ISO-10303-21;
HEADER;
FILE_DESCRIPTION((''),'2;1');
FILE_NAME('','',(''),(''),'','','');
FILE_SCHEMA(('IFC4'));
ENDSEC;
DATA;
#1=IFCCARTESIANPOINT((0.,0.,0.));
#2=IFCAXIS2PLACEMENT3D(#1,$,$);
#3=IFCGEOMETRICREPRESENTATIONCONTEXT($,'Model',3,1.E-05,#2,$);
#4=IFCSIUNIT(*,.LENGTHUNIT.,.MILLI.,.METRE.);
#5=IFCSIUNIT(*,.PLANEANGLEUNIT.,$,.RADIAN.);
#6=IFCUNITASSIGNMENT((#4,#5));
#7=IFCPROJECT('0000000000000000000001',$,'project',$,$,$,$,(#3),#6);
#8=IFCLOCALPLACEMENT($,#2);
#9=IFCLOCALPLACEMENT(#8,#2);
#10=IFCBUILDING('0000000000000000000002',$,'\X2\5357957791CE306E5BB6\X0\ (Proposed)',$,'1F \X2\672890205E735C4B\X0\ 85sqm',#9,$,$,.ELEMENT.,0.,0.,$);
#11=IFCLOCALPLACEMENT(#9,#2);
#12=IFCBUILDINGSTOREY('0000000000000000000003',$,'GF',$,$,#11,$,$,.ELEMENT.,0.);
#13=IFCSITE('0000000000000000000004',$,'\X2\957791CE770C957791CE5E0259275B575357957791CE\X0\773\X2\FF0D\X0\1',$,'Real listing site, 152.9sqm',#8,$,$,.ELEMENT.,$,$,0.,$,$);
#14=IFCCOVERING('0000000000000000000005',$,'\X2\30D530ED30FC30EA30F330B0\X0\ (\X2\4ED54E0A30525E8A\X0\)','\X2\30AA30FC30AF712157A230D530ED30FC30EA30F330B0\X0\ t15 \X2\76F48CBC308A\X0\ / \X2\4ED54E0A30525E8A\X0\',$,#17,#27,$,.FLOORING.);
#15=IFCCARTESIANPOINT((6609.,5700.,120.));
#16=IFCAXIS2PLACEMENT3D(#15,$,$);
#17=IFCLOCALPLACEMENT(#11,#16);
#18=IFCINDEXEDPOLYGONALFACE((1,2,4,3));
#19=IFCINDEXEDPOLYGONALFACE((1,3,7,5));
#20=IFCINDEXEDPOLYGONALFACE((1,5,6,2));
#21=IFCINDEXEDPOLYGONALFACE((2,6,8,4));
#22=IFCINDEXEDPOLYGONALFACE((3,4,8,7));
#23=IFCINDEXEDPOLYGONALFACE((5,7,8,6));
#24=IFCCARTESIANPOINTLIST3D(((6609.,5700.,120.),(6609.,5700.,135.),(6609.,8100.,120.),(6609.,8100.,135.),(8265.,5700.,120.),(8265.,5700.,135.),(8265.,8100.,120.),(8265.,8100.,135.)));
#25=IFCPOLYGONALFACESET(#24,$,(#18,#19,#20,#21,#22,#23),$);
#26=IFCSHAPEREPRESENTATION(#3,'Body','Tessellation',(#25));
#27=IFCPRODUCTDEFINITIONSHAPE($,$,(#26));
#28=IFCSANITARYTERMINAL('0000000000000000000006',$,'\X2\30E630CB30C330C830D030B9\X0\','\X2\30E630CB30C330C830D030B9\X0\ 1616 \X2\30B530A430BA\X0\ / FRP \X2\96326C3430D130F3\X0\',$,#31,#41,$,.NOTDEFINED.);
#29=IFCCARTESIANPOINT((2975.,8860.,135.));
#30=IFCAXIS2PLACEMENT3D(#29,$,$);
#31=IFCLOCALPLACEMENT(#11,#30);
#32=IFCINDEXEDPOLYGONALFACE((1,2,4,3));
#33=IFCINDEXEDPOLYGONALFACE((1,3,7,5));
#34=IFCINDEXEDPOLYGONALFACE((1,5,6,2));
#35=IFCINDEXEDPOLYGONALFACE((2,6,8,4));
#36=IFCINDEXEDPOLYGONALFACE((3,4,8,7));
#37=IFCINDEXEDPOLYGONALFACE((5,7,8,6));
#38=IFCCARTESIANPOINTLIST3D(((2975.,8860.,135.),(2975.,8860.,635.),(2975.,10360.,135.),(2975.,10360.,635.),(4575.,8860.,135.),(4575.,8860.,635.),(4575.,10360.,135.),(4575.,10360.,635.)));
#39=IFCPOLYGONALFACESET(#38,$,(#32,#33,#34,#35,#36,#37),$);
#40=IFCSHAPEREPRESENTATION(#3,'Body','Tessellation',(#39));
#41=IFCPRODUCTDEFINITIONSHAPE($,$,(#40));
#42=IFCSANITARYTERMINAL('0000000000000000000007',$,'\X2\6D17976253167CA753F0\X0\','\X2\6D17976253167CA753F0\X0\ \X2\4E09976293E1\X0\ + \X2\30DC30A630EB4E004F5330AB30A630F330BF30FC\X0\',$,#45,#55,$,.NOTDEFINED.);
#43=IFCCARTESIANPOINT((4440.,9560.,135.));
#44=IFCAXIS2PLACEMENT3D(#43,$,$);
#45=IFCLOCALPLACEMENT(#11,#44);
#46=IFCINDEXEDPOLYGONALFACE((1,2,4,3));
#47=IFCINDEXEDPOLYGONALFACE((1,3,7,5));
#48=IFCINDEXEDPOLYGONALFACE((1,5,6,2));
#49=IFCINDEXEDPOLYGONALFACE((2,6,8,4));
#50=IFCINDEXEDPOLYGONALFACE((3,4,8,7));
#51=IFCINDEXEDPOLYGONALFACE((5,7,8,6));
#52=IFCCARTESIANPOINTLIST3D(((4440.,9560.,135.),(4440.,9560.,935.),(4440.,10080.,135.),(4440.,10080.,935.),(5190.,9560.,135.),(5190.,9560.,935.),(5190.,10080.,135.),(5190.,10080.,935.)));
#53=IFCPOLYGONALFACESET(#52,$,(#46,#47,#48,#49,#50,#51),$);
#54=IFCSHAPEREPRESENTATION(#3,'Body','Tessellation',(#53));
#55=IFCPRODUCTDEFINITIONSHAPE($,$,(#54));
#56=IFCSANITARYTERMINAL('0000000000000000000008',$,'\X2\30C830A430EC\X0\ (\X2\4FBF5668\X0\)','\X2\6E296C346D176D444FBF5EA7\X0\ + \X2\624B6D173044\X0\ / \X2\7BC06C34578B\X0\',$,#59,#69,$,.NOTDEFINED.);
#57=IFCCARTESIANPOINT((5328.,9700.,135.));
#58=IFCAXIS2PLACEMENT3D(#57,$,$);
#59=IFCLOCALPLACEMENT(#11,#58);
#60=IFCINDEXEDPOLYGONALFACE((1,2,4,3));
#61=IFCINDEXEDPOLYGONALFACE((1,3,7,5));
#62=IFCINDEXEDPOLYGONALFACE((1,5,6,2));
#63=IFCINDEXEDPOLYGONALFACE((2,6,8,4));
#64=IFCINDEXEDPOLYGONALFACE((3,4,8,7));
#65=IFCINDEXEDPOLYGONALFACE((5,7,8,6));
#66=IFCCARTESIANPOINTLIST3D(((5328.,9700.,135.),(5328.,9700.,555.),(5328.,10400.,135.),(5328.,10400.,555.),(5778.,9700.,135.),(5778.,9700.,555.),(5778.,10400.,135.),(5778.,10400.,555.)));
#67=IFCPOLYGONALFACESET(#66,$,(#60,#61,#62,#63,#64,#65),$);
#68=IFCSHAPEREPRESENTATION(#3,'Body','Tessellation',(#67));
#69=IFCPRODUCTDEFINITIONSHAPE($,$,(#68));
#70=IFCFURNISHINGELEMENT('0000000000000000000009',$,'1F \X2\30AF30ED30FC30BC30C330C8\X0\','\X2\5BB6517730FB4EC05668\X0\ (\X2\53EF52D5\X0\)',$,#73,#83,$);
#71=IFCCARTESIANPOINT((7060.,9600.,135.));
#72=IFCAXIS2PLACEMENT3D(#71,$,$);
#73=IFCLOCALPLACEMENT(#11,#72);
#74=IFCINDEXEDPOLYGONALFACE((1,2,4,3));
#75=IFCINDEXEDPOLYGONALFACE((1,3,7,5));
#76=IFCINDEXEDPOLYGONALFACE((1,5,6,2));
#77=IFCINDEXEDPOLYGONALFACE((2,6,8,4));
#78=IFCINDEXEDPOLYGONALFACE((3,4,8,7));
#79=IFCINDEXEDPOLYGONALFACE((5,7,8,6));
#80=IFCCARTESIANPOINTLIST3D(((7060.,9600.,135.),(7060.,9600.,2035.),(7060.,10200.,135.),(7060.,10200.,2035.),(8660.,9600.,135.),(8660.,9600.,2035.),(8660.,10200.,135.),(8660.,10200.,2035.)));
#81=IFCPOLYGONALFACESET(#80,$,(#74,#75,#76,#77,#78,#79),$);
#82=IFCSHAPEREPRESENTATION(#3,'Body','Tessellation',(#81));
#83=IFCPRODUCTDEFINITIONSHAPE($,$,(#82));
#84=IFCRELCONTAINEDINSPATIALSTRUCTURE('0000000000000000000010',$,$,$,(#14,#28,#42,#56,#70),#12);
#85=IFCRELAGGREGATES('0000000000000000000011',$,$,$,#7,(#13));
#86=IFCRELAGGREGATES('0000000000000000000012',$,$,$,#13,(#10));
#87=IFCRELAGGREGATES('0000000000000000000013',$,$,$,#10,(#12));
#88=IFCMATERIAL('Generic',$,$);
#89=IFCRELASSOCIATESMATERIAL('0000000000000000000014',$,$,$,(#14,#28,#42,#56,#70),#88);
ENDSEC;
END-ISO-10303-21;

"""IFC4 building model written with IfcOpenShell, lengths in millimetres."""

from ifc_helpers import new_model, si_unit, frame, frame_2d, origin, place, context, project, spatial, rectangle, extrude, material, element, save


model = new_model("IFC4")

# Units and contexts
model_context = context("Model", 3, precision=1e-05, world=origin())
ifc_project = project(units=[si_unit("LENGTHUNIT", "METRE", prefix="MILLI"), si_unit("PLANEANGLEUNIT", "RADIAN")], contexts=[model_context])

# Site, building, storey
site_placement = place(None, origin())
site = spatial("IfcSite", under=ifc_project, at=site_placement, Name="長野県長野市大字南長野773－1", ObjectType="Real listing site, 152.9sqm", CompositionType="ELEMENT", RefElevation=0.0)
building_placement = place(site_placement, origin())
building = spatial("IfcBuilding", under=site, at=building_placement, Name="南長野の家 (Proposed)", ObjectType="1F 木造平屋 85sqm", CompositionType="ELEMENT", ElevationOfRefHeight=0.0, ElevationOfTerrain=0.0)
storey_placement = place(building_placement, origin())
storey = spatial("IfcBuildingStorey", under=building, at=storey_placement, Name="GF", CompositionType="ELEMENT", Elevation=0.0)

# Covering
ifc_material_1 = material(Name="Generic")
covering_1_placement = place(storey_placement, frame((6609.0, 5700.0, 120.0)))
element("IfcCovering", 1, at=covering_1_placement, inside=storey, material=ifc_material_1, Name="フローリング (仕上げ床)", Description="オーク無垢フローリング t15 直貼り / 仕上げ床", PredefinedType="FLOORING", context=model_context, shape_type="SweptSolid", body=[
    extrude(rectangle(XDim=1656.0, YDim=2400.0, at=frame_2d((828.0, 1200.0))), frame((6609.0, 5700.0, 120.0)), (0.0, 0.0, 1.0), 15.0),
])

# Sanitary terminals
sanitary_terminal_1_placement = place(storey_placement, frame((2975.0, 8860.0, 135.0)))
element("IfcSanitaryTerminal", 2, at=sanitary_terminal_1_placement, inside=storey, material=ifc_material_1, Name="ユニットバス", Description="ユニットバス 1616 サイズ / FRP 防水パン", PredefinedType="NOTDEFINED", context=model_context, shape_type="SweptSolid", body=[
    extrude(rectangle(XDim=1600.0, YDim=1500.0, at=frame_2d((800.0, 750.0))), frame((2975.0, 8860.0, 135.0)), (0.0, 0.0, 1.0), 500.0),
])
sanitary_terminal_2_placement = place(storey_placement, frame((4440.0, 9560.0, 135.0)))
element("IfcSanitaryTerminal", 3, at=sanitary_terminal_2_placement, inside=storey, material=ifc_material_1, Name="洗面化粧台", Description="洗面化粧台 三面鏡 + ボウル一体カウンター", PredefinedType="NOTDEFINED", context=model_context, shape_type="SweptSolid", body=[
    extrude(rectangle(XDim=750.0, YDim=520.0, at=frame_2d((375.0, 260.0))), frame((4440.0, 9560.0, 135.0)), (0.0, 0.0, 1.0), 800.0),
])
sanitary_terminal_3_placement = place(storey_placement, frame((5328.0, 9700.0, 135.0)))
element("IfcSanitaryTerminal", 4, at=sanitary_terminal_3_placement, inside=storey, material=ifc_material_1, Name="トイレ (便器)", Description="温水洗浄便座 + 手洗い / 節水型", PredefinedType="NOTDEFINED", context=model_context, shape_type="SweptSolid", body=[
    extrude(rectangle(XDim=450.0, YDim=700.0, at=frame_2d((225.0, 350.0))), frame((5328.0, 9700.0, 135.0)), (0.0, 0.0, 1.0), 420.0),
])

# Furnishing element
furnishing_placement = place(storey_placement, frame((7060.0, 9600.0, 135.0)))
element("IfcFurnishingElement", 5, at=furnishing_placement, inside=storey, material=ifc_material_1, Name="1F クローゼット", Description="家具・什器 (可動)", context=model_context, shape_type="SweptSolid", body=[
    extrude(rectangle(XDim=1600.0, YDim=600.0, at=frame_2d((800.0, 300.0))), frame((7060.0, 9600.0, 135.0)), (0.0, 0.0, 1.0), 1900.0),
])

save(model, "model.ifc")
